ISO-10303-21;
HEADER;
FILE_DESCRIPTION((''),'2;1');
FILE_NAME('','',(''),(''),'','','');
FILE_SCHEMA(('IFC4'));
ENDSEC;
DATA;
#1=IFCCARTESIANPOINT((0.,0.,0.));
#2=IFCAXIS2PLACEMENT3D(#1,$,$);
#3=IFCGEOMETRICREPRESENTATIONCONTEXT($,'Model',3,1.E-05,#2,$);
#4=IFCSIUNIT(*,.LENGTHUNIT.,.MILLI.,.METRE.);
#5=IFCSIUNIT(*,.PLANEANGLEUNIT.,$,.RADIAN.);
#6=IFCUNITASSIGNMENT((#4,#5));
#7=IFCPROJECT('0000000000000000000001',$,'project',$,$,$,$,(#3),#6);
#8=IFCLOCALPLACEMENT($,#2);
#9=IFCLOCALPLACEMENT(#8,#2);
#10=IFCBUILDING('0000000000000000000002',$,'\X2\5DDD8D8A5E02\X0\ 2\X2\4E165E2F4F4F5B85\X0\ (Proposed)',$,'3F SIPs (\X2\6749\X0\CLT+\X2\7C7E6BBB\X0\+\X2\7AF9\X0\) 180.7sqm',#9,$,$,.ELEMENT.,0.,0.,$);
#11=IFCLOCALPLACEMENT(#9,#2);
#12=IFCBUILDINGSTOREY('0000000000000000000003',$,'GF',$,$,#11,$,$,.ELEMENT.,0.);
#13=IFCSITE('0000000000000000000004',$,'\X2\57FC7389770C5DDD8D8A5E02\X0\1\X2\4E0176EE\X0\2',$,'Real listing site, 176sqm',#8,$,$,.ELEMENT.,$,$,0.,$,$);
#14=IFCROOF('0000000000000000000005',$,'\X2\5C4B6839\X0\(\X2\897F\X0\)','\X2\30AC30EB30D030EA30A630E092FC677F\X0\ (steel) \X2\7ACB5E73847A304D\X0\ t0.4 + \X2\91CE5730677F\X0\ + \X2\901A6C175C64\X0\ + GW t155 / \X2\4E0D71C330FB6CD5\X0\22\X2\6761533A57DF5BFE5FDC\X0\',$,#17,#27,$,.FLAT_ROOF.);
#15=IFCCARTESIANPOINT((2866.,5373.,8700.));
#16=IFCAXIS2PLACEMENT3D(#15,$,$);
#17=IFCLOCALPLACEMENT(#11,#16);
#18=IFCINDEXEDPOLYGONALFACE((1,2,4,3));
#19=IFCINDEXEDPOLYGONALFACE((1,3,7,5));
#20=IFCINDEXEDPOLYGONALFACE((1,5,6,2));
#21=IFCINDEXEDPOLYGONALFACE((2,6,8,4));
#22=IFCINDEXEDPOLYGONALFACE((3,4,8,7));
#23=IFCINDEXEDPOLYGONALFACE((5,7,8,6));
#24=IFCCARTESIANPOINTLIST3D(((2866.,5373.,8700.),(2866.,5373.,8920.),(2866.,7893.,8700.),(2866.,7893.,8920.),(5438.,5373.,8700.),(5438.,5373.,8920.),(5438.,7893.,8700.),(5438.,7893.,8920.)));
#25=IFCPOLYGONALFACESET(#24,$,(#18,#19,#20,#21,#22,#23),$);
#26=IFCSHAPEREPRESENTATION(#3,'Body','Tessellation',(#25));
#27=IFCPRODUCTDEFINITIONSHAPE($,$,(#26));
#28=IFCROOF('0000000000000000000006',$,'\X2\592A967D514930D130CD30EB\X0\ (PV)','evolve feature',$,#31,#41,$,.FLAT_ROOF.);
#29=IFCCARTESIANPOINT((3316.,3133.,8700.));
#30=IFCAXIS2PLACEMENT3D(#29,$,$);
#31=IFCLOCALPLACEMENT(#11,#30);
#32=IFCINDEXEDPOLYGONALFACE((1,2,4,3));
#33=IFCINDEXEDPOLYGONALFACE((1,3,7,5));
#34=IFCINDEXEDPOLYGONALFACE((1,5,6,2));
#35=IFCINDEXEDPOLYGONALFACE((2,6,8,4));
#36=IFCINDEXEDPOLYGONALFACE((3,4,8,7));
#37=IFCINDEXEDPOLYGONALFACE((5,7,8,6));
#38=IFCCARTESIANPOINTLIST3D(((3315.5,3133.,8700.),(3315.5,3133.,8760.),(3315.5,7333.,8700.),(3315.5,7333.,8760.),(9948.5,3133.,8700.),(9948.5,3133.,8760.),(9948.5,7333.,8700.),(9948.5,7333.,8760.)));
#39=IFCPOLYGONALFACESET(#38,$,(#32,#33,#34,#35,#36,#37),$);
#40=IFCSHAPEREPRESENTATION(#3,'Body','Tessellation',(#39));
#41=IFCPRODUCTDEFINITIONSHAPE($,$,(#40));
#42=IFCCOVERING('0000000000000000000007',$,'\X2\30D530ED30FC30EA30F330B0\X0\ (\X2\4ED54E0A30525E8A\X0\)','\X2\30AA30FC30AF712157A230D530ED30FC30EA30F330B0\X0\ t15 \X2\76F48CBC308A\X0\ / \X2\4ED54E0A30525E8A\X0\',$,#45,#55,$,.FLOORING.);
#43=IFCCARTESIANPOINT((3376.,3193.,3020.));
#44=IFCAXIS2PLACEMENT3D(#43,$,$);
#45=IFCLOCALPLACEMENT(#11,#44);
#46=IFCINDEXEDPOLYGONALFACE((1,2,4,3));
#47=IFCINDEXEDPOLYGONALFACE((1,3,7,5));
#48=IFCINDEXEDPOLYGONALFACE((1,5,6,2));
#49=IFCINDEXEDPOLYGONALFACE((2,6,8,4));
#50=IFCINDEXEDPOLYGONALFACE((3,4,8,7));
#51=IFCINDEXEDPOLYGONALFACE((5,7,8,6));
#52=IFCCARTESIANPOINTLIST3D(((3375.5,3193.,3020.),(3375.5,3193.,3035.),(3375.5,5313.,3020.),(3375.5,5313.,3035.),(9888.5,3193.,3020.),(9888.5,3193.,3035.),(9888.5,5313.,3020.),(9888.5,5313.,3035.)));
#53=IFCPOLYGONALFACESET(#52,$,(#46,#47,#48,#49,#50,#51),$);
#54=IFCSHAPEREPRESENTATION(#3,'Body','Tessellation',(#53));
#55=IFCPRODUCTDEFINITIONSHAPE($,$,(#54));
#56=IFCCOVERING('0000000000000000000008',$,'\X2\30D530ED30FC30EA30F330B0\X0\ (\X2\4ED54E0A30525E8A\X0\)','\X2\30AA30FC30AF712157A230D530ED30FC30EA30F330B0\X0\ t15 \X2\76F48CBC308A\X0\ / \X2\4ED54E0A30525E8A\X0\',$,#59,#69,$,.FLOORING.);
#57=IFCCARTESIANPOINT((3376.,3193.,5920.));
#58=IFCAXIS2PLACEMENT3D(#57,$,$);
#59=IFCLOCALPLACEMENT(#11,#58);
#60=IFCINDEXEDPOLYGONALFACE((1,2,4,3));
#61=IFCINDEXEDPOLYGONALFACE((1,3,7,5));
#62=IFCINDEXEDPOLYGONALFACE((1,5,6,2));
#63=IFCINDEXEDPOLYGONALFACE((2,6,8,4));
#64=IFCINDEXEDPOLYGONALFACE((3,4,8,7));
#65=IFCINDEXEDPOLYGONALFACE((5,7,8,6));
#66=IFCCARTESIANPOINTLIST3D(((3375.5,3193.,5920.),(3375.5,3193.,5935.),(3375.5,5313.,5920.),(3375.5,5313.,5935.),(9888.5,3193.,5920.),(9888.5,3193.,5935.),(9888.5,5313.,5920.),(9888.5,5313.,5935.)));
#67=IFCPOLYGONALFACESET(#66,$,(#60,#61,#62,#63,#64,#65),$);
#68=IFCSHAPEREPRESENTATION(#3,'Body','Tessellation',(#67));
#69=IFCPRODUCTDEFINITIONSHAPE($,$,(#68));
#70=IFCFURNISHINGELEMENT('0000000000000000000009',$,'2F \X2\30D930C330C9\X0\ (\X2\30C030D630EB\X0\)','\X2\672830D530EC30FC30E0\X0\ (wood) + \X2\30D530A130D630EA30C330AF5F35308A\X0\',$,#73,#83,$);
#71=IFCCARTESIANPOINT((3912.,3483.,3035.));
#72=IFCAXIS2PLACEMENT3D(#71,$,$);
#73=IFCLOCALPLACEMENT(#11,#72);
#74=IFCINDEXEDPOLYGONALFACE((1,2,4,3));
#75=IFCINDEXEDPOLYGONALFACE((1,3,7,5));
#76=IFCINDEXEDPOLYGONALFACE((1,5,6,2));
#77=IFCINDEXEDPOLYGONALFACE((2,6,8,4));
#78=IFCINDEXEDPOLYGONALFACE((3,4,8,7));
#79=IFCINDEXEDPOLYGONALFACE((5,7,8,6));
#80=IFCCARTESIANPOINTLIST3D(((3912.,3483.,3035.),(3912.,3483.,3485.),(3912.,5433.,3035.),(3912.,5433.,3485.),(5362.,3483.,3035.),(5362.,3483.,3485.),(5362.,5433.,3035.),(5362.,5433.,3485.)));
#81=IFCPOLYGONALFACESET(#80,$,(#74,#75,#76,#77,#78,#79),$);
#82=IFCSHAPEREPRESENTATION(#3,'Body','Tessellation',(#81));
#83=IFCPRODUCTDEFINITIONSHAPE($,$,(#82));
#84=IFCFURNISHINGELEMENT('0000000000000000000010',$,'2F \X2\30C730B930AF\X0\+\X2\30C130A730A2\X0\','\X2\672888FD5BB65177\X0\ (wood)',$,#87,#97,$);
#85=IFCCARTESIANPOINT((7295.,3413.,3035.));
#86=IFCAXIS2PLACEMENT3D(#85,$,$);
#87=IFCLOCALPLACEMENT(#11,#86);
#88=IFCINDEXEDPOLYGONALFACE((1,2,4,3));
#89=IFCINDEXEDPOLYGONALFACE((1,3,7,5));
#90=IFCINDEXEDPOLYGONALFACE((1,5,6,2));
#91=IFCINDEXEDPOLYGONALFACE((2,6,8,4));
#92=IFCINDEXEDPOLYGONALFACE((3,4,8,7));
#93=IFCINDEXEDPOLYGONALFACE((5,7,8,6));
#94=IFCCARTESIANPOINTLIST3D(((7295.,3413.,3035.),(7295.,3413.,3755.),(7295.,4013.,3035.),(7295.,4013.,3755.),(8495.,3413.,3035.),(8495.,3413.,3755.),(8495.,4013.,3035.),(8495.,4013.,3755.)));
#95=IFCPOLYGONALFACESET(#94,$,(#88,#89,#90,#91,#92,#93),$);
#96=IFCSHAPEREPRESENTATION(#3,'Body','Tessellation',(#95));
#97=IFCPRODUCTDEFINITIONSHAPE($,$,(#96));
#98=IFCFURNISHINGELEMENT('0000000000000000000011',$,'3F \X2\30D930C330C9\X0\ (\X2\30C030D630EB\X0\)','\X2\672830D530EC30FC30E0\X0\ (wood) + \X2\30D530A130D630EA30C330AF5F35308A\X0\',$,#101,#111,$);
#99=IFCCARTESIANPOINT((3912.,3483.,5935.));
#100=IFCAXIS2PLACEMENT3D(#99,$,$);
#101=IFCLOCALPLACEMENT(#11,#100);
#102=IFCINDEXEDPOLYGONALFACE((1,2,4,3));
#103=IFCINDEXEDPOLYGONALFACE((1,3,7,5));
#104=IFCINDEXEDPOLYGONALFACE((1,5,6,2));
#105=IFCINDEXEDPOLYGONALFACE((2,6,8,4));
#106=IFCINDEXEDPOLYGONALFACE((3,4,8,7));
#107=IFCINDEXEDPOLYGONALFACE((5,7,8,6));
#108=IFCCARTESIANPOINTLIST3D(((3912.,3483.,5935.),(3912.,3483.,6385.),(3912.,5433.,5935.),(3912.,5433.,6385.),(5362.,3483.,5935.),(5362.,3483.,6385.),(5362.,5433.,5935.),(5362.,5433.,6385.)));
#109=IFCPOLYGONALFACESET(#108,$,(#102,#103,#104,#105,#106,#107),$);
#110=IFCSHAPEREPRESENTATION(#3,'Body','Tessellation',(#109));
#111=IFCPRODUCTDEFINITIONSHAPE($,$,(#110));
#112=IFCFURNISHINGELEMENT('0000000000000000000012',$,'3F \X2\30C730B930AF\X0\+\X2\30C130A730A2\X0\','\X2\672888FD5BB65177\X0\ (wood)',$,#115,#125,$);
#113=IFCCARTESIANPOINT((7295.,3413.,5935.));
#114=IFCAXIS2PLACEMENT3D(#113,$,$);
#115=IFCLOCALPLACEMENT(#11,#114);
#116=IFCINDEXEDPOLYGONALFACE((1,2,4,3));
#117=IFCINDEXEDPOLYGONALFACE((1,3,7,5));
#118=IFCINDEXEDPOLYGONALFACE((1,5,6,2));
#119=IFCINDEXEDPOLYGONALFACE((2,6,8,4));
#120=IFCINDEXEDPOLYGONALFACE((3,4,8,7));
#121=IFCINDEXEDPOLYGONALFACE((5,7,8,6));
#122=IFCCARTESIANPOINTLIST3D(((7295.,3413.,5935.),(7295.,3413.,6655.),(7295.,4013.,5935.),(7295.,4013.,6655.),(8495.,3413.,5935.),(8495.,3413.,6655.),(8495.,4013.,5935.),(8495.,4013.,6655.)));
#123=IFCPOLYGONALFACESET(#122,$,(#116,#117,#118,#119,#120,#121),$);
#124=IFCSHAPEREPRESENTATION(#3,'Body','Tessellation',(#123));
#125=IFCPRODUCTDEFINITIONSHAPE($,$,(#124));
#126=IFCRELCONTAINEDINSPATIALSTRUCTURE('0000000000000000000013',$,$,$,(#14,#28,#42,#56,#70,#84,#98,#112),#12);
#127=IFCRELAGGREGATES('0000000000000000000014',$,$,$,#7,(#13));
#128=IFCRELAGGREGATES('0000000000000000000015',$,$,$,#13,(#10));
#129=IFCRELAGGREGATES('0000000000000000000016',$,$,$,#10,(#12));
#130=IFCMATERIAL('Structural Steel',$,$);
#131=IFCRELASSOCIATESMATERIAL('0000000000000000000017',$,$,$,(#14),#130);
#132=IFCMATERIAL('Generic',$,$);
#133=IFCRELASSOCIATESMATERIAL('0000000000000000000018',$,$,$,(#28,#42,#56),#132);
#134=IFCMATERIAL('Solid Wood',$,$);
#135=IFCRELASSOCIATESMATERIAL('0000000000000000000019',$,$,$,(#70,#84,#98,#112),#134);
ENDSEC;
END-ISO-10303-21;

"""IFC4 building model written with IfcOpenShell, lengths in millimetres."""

from ifc_helpers import new_model, si_unit, frame, frame_2d, origin, place, context, project, spatial, rectangle, extrude, material, element, save


model = new_model("IFC4")

# Units and contexts
model_context = context("Model", 3, precision=1e-05, world=origin())
ifc_project = project(units=[si_unit("LENGTHUNIT", "METRE", prefix="MILLI"), si_unit("PLANEANGLEUNIT", "RADIAN")], contexts=[model_context])

# Site, building, storey
site_placement = place(None, origin())
site = spatial("IfcSite", under=ifc_project, at=site_placement, Name="埼玉県川越市1丁目2", ObjectType="Real listing site, 176sqm", CompositionType="ELEMENT", RefElevation=0.0)
building_placement = place(site_placement, origin())
building = spatial("IfcBuilding", under=site, at=building_placement, Name="川越市 2世帯住宅 (Proposed)", ObjectType="3F SIPs (杉CLT+籾殻+竹) 180.7sqm", CompositionType="ELEMENT", ElevationOfRefHeight=0.0, ElevationOfTerrain=0.0)
storey_placement = place(building_placement, origin())
storey = spatial("IfcBuildingStorey", under=building, at=storey_placement, Name="GF", CompositionType="ELEMENT", Elevation=0.0)

# Shared definitions
ifc_material_1 = material(Name="Solid Wood")

# Roofs
ifc_material_2 = material(Name="Structural Steel")
roof_1_placement = place(storey_placement, frame((2866.0, 5373.0, 8700.0)))
element("IfcRoof", 1, at=roof_1_placement, inside=storey, material=ifc_material_2, Name="屋根(西)", Description="ガルバリウム鋼板 (steel) 立平葺き t0.4 + 野地板 + 通気層 + GW t155 / 不燃・法22条区域対応", PredefinedType="FLAT_ROOF", context=model_context, shape_type="SweptSolid", body=[
    extrude(rectangle(XDim=2572.0, YDim=2520.0, at=frame_2d((1286.0, 1260.0))), frame((2866.0, 5373.0, 8700.0)), (0.0, 0.0, 1.0), 220.0),
])
ifc_material_3 = material(Name="Generic")
roof_2_placement = place(storey_placement, frame((3316.0, 3133.0, 8700.0)))
element("IfcRoof", 2, at=roof_2_placement, inside=storey, material=ifc_material_3, Name="太陽光パネル (PV)", Description="evolve feature", PredefinedType="FLAT_ROOF", context=model_context, shape_type="SweptSolid", body=[
    extrude(rectangle(XDim=6633.0, YDim=4200.0, at=frame_2d((3316.0, 2100.0))), frame((3316.0, 3133.0, 8700.0)), (0.0, 0.0, 1.0), 60.0),
])

# Coverings
covering_1_placement = place(storey_placement, frame((3376.0, 3193.0, 3020.0)))
element("IfcCovering", 3, at=covering_1_placement, inside=storey, material=ifc_material_3, Name="フローリング (仕上げ床)", Description="オーク無垢フローリング t15 直貼り / 仕上げ床", PredefinedType="FLOORING", context=model_context, shape_type="SweptSolid", body=[
    extrude(rectangle(XDim=6513.0, YDim=2120.0, at=frame_2d((3256.0, 1060.0))), frame((3376.0, 3193.0, 3020.0)), (0.0, 0.0, 1.0), 15.0),
])
covering_2_placement = place(storey_placement, frame((3376.0, 3193.0, 5920.0)))
element("IfcCovering", 4, at=covering_2_placement, inside=storey, material=ifc_material_3, Name="フローリング (仕上げ床)", Description="オーク無垢フローリング t15 直貼り / 仕上げ床", PredefinedType="FLOORING", context=model_context, shape_type="SweptSolid", body=[
    extrude(rectangle(XDim=6513.0, YDim=2120.0, at=frame_2d((3256.0, 1060.0))), frame((3376.0, 3193.0, 5920.0)), (0.0, 0.0, 1.0), 15.0),
])

# Furnishing elements
furnishing_1_placement = place(storey_placement, frame((3912.0, 3483.0, 3035.0)))
element("IfcFurnishingElement", 5, at=furnishing_1_placement, inside=storey, material=ifc_material_1, Name="2F ベッド (ダブル)", Description="木フレーム (wood) + ファブリック張り", context=model_context, shape_type="SweptSolid", body=[
    extrude(rectangle(XDim=1450.0, YDim=1950.0, at=frame_2d((725.0, 975.0))), frame((3912.0, 3483.0, 3035.0)), (0.0, 0.0, 1.0), 450.0),
])
furnishing_2_placement = place(storey_placement, frame((7295.0, 3413.0, 3035.0)))
element("IfcFurnishingElement", 6, at=furnishing_2_placement, inside=storey, material=ifc_material_1, Name="2F デスク+チェア", Description="木製家具 (wood)", context=model_context, shape_type="SweptSolid", body=[
    extrude(rectangle(XDim=1200.0, YDim=600.0, at=frame_2d((600.0, 300.0))), frame((7295.0, 3413.0, 3035.0)), (0.0, 0.0, 1.0), 720.0),
])
furnishing_3_placement = place(storey_placement, frame((3912.0, 3483.0, 5935.0)))
element("IfcFurnishingElement", 7, at=furnishing_3_placement, inside=storey, material=ifc_material_1, Name="3F ベッド (ダブル)", Description="木フレーム (wood) + ファブリック張り", context=model_context, shape_type="SweptSolid", body=[
    extrude(rectangle(XDim=1450.0, YDim=1950.0, at=frame_2d((725.0, 975.0))), frame((3912.0, 3483.0, 5935.0)), (0.0, 0.0, 1.0), 450.0),
])
furnishing_4_placement = place(storey_placement, frame((7295.0, 3413.0, 5935.0)))
element("IfcFurnishingElement", 8, at=furnishing_4_placement, inside=storey, material=ifc_material_1, Name="3F デスク+チェア", Description="木製家具 (wood)", context=model_context, shape_type="SweptSolid", body=[
    extrude(rectangle(XDim=1200.0, YDim=600.0, at=frame_2d((600.0, 300.0))), frame((7295.0, 3413.0, 5935.0)), (0.0, 0.0, 1.0), 720.0),
])

save(model, "model.ifc")
